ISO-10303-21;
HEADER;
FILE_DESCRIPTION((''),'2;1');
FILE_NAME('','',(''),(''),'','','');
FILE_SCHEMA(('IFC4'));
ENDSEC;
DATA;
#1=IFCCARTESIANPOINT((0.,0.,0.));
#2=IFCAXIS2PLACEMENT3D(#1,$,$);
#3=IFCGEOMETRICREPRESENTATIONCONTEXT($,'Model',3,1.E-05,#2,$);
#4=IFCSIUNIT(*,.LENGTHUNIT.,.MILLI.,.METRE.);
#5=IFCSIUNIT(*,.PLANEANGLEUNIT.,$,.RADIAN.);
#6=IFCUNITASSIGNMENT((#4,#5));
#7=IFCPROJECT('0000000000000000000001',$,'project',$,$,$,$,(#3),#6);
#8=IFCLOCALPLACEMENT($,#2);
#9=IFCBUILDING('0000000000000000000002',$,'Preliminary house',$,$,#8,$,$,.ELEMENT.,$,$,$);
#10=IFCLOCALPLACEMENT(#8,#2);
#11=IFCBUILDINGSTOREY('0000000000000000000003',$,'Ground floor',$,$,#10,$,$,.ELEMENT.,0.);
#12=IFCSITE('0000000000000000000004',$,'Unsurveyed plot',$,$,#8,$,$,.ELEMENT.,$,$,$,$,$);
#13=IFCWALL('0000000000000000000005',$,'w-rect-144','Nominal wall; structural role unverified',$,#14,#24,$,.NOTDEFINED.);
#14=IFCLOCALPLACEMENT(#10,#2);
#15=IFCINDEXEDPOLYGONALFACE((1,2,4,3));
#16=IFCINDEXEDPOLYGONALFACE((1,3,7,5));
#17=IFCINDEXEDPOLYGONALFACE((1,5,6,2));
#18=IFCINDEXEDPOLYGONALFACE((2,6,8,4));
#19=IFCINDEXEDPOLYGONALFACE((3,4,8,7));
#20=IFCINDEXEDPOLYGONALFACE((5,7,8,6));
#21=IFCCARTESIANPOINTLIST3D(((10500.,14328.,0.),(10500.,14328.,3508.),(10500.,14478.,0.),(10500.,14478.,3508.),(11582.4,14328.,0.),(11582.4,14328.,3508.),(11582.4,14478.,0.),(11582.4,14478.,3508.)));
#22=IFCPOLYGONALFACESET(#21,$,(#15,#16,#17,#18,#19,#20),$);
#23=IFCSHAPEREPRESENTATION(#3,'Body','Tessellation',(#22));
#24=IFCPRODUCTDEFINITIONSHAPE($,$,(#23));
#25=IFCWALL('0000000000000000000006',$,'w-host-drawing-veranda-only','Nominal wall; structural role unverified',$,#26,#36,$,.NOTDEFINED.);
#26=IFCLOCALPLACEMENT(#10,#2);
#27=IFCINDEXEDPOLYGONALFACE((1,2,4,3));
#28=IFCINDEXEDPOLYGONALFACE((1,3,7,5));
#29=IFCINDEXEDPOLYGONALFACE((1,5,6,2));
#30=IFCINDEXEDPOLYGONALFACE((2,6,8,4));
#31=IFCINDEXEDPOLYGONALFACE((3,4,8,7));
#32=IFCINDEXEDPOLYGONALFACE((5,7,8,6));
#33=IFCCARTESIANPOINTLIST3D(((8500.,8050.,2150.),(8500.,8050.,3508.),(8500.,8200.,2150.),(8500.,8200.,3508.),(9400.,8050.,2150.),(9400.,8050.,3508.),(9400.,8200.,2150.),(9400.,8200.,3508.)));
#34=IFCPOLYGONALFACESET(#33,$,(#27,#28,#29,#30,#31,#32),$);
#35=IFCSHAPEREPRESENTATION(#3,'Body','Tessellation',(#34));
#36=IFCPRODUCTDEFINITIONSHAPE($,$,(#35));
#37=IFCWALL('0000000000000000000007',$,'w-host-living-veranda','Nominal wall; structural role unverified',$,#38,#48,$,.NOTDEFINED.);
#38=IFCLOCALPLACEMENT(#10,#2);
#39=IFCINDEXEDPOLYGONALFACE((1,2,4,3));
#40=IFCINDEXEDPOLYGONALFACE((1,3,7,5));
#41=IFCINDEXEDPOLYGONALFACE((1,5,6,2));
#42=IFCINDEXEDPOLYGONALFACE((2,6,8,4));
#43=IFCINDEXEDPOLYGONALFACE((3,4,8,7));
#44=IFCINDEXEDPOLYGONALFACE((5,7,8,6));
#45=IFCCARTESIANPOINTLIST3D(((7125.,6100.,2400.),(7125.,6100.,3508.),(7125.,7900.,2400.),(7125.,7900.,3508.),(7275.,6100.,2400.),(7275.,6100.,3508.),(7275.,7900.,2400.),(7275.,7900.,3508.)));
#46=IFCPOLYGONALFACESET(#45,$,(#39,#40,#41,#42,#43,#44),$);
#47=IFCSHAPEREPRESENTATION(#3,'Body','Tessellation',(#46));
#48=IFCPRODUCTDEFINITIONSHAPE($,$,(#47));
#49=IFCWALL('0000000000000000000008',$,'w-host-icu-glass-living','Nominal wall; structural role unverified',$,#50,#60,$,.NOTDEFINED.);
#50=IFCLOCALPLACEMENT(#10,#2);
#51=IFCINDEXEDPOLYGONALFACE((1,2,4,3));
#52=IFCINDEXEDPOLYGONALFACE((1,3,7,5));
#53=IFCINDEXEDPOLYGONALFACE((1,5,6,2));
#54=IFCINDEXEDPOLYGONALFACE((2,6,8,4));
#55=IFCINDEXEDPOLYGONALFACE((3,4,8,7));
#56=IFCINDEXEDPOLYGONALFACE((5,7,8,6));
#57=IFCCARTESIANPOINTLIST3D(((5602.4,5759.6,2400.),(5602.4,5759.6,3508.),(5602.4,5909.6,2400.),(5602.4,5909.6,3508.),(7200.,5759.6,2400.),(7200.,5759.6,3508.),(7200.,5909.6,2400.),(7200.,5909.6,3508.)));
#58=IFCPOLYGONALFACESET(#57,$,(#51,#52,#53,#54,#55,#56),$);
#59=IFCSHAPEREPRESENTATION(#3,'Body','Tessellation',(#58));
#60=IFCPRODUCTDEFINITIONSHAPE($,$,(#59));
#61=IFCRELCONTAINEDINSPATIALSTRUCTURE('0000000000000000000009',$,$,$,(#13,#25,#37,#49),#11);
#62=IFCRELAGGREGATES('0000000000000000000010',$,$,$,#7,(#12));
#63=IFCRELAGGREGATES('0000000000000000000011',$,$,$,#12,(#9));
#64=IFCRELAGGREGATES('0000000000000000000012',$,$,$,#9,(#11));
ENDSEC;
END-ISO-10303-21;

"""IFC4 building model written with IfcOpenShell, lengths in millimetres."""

from ifc_helpers import new_model, si_unit, origin, place, context, project, spatial, polyline, outline, extrude, element, save


model = new_model("IFC4")

# Units and contexts
model_context = context("Model", 3, precision=1e-05, world=origin())
ifc_project = project(units=[si_unit("LENGTHUNIT", "METRE", prefix="MILLI"), si_unit("PLANEANGLEUNIT", "RADIAN")], contexts=[model_context])

# Site, building, storey
placement_1 = place(None, origin())
site = spatial("IfcSite", under=ifc_project, at=placement_1, Name="Unsurveyed plot", CompositionType="ELEMENT")
building = spatial("IfcBuilding", under=site, at=placement_1, Name="Preliminary house", CompositionType="ELEMENT")
placement_2 = place(placement_1, origin())
storey = spatial("IfcBuildingStorey", under=building, at=placement_2, Name="Ground floor", CompositionType="ELEMENT", Elevation=0.0)

# Wall
element("IfcWall", 1, at=placement_2, inside=storey, Name="w-rect-144", Description="Nominal wall; structural role unverified", PredefinedType="NOTDEFINED", context=model_context, shape_type="SweptSolid", body=[
    extrude(outline(polyline([(10500.0, 14328.0), (11582.4, 14328.0), (11582.4, 14478.0), (10500.0, 14478.0), (10500.0, 14328.0)])), origin(), (0.0, 0.0, 1.0), 3508.0),
])

# Walls, openings
wall_1 = element("IfcWall", 2, at=placement_2, inside=storey, Name="w-host-drawing-veranda-only", Description="Nominal wall; structural role unverified", PredefinedType="NOTDEFINED", context=model_context, shape_type="SweptSolid", body=[
    extrude(outline(polyline([(8500.0, 8050.0), (9400.0, 8050.0), (9400.0, 8200.0), (8500.0, 8200.0), (8500.0, 8050.0)])), origin(), (0.0, 0.0, 1.0), 3508.0),
])
element("IfcOpeningElement", 3, at=placement_2, cuts=wall_1, PredefinedType="OPENING", context=model_context, shape_type="SweptSolid", body=[
    extrude(outline(polyline([(8500.0, 7675.0), (9400.0, 7675.0), (9400.0, 8575.0), (8500.0, 8575.0), (8500.0, 7675.0)])), origin(), (0.0, 0.0, 1.0), 2150.0),
])
wall_2 = element("IfcWall", 4, at=placement_2, inside=storey, Name="w-host-living-veranda", Description="Nominal wall; structural role unverified", PredefinedType="NOTDEFINED", context=model_context, shape_type="SweptSolid", body=[
    extrude(outline(polyline([(7275.0, 6100.0), (7275.0, 7900.0), (7125.0, 7900.0), (7125.0, 6100.0), (7275.0, 6100.0)])), origin(), (0.0, 0.0, 1.0), 3508.0),
])
element("IfcOpeningElement", 5, at=placement_2, cuts=wall_2, PredefinedType="OPENING", context=model_context, shape_type="SweptSolid", body=[
    extrude(outline(polyline([(7650.0, 6100.0), (7650.0, 7900.0), (6750.0, 7900.0), (6750.0, 6100.0), (7650.0, 6100.0)])), origin(), (0.0, 0.0, 1.0), 2400.0),
])
wall_3 = element("IfcWall", 6, at=placement_2, inside=storey, Name="w-host-icu-glass-living", Description="Nominal wall; structural role unverified", PredefinedType="NOTDEFINED", context=model_context, shape_type="SweptSolid", body=[
    extrude(outline(polyline([(5602.4, 5759.6), (7200.0, 5759.6), (7200.0, 5909.6), (5602.4, 5909.6), (5602.4, 5759.6)])), origin(), (0.0, 0.0, 1.0), 3508.0),
])
element("IfcOpeningElement", 7, at=placement_2, cuts=wall_3, PredefinedType="OPENING", context=model_context, shape_type="SweptSolid", body=[
    extrude(outline(polyline([(5602.4, 5384.6), (7200.0, 5384.6), (7200.0, 6284.6), (5602.4, 6284.6), (5602.4, 5384.6)])), origin(), (0.0, 0.0, 1.0), 2400.0),
])

save(model, "model.ifc")
